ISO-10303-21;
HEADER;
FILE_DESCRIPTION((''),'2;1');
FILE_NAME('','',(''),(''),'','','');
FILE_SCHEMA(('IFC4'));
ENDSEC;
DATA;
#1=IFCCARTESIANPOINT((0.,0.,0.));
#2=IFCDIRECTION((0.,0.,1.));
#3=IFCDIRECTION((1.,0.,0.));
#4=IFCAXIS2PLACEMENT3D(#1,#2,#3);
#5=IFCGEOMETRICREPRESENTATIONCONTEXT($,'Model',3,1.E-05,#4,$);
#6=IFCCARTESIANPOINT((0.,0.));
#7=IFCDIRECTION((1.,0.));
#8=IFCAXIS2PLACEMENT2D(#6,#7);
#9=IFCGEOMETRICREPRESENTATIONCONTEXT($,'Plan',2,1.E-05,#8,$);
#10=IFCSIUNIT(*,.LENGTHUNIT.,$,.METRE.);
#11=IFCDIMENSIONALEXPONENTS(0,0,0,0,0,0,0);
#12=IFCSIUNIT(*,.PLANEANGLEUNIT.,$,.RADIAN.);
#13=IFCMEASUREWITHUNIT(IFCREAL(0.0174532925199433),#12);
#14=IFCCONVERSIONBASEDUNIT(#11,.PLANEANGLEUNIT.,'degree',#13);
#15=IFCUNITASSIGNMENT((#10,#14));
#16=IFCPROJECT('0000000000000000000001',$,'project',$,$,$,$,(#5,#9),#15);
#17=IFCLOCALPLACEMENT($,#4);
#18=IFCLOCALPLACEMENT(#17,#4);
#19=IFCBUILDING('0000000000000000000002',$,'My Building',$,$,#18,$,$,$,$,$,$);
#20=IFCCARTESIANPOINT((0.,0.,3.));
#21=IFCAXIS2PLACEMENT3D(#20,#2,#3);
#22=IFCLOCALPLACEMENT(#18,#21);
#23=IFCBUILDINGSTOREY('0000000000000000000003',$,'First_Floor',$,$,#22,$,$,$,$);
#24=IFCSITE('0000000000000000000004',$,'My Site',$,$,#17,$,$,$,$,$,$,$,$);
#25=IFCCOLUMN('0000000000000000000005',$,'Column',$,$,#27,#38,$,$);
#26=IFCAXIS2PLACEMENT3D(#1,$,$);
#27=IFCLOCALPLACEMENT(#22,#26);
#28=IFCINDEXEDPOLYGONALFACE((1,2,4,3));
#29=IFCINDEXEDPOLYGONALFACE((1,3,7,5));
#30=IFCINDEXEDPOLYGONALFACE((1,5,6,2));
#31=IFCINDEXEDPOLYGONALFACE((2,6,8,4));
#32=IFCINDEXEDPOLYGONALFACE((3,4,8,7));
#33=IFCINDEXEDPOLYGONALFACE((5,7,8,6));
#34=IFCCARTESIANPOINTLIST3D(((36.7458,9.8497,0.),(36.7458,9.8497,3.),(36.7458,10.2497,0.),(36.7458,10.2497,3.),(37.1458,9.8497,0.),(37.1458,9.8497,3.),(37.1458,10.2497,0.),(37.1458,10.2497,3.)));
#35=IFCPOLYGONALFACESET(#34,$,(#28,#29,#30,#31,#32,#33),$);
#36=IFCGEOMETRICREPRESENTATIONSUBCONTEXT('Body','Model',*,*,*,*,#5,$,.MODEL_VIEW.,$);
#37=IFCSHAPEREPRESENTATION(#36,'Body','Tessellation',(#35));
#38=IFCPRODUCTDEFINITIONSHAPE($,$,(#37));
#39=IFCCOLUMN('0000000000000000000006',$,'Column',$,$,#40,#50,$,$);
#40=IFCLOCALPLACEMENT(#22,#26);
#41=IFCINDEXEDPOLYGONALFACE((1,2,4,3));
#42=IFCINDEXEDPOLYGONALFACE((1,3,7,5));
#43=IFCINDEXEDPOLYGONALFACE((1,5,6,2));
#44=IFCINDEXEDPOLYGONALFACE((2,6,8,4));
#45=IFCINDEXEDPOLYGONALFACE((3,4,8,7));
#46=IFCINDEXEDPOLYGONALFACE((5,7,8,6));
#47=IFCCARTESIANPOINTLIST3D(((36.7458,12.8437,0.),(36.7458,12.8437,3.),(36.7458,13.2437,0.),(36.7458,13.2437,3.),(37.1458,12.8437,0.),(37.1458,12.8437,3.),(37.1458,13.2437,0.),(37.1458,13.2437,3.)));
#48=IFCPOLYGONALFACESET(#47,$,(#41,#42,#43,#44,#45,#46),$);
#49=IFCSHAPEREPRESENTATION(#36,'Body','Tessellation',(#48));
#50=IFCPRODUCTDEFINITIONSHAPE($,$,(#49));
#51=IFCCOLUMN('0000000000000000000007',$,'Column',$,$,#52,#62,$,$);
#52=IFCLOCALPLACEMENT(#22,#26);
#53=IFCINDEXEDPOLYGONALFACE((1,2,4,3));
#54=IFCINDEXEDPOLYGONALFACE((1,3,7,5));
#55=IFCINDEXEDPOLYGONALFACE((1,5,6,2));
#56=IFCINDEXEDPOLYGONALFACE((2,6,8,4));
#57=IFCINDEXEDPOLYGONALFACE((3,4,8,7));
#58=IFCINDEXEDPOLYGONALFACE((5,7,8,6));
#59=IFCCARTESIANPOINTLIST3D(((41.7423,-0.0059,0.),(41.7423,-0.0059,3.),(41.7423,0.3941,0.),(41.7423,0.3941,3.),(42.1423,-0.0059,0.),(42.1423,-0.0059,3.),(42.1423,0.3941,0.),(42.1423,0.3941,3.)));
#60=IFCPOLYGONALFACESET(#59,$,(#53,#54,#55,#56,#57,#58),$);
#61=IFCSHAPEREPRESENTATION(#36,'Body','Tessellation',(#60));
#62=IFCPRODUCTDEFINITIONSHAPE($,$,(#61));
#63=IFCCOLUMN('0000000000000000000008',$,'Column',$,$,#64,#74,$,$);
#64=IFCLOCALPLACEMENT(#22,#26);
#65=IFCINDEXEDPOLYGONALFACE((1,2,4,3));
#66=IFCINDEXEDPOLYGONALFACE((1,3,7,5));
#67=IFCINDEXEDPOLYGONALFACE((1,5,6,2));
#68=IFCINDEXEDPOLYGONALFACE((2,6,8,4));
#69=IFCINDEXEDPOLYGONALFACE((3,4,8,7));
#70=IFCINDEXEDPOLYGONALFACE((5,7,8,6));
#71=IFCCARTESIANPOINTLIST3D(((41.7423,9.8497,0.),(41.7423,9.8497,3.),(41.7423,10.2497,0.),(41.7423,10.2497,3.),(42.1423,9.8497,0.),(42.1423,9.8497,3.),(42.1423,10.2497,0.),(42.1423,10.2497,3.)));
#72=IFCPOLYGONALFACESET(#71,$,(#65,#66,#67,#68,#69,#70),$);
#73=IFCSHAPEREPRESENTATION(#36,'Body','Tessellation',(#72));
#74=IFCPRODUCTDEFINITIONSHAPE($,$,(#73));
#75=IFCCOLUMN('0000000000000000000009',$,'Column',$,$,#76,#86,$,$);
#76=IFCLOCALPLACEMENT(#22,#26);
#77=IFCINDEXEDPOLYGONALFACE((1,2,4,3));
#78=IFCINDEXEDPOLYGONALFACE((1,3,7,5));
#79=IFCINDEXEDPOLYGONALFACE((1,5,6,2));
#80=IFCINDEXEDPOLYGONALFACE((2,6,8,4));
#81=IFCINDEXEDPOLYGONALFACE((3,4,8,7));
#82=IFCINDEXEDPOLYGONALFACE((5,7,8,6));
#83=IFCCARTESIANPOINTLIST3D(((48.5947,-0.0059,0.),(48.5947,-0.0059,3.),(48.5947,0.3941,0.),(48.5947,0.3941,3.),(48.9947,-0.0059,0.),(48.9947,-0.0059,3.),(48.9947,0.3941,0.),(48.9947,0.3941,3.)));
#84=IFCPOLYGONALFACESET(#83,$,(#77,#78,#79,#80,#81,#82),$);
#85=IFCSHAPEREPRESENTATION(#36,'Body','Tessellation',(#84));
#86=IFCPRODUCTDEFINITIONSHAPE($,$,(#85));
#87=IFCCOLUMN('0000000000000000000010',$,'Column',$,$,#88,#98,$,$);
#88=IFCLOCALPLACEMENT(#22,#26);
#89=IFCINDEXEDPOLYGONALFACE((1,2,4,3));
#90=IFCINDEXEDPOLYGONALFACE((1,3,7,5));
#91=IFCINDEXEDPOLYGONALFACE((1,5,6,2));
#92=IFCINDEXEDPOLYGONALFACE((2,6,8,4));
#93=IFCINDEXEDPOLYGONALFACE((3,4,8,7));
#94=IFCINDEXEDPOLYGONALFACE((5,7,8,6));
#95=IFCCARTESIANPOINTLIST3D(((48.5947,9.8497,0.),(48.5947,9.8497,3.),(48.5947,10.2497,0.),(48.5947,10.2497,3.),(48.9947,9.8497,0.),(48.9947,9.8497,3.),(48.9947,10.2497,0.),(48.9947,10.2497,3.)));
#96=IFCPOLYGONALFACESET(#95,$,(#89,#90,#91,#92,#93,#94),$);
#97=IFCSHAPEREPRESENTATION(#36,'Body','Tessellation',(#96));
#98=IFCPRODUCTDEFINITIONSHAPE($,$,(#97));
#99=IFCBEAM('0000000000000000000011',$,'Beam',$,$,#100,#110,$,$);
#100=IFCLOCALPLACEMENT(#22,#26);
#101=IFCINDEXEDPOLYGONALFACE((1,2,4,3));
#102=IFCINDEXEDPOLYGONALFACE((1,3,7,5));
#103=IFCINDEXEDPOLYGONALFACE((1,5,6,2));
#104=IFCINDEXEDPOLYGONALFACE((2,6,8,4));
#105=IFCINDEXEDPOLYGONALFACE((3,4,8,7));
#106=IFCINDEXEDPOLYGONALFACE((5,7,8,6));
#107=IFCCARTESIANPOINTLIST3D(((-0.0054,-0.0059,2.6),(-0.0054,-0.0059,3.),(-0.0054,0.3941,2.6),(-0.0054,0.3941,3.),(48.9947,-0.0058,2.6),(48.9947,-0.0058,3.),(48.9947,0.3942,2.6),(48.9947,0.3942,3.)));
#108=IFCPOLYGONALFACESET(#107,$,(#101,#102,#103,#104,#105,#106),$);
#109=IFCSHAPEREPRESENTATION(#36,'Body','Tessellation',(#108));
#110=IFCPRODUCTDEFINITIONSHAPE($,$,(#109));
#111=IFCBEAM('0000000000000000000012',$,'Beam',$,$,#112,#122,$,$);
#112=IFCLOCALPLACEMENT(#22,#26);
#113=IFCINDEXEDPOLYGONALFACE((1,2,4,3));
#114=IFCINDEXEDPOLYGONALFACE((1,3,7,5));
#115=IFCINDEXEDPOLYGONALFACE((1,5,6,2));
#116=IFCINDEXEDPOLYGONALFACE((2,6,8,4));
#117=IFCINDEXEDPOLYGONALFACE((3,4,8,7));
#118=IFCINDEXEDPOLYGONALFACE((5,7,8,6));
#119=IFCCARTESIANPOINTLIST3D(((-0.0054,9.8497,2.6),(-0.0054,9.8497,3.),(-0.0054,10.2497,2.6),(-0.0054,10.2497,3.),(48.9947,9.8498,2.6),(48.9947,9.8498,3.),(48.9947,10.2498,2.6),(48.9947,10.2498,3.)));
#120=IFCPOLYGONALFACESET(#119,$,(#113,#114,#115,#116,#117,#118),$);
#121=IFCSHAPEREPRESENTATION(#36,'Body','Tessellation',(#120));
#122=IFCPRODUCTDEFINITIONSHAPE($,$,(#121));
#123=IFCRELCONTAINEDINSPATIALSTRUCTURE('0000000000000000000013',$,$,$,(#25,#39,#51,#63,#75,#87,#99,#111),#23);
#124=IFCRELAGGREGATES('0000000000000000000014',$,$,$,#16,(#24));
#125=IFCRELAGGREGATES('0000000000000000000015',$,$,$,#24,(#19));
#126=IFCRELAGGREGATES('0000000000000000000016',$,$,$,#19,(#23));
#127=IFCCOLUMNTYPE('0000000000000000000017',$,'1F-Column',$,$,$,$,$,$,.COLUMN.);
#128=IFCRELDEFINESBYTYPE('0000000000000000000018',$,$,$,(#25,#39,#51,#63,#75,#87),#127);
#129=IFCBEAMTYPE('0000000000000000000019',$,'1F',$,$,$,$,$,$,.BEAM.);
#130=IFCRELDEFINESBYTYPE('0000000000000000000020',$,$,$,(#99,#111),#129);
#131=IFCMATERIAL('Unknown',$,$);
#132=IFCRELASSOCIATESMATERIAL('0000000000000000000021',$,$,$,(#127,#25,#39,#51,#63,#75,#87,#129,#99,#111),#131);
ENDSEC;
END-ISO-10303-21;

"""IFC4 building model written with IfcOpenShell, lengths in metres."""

from ifc_helpers import new_model, entity, si_unit, converted_unit, frame, origin_with_axes, origin_2d_with_axis, place, context, subcontext, project, spatial, rectangle, extrude, material, material_profile, profile_set, profile_usage, type_object, element, save


model = new_model("IFC4")

# Units and contexts
model_context = context("Model", 3, precision=1e-05, world=origin_with_axes())
plan_context = context("Plan", 2, precision=1e-05, world=origin_2d_with_axis())
body_context_1 = subcontext(model_context, "Body", "Model", "MODEL_VIEW")
ifc_project = project(units=[si_unit("LENGTHUNIT", "METRE"), converted_unit("PLANEANGLEUNIT", "degree", entity("IfcReal", 0.0174532925199433), si_unit("PLANEANGLEUNIT", "RADIAN"), dimensions=[0, 0, 0, 0, 0, 0, 0])], contexts=[model_context, plan_context])

# Site, building, storey
site_placement = place(None, origin_with_axes())
site = spatial("IfcSite", under=ifc_project, at=site_placement, Name="My Site")
building_placement = place(site_placement, origin_with_axes())
building = spatial("IfcBuilding", under=site, at=building_placement, Name="My Building")
storey_placement = place(building_placement, frame((0.0, 0.0, 3.0), z_axis=(0.0, 0.0, 1.0), x_axis=(1.0, 0.0, 0.0)))
storey = spatial("IfcBuildingStorey", under=building, at=storey_placement, Name="First_Floor")

# Columns
ifc_material = material(Name="Unknown")
ifc_material_profile_1 = material_profile(ifc_material, rectangle(XDim=0.4, YDim=0.4))
ifc_profile_set_1 = profile_set([ifc_material_profile_1])
ifc_profile_usage_1 = profile_usage(ifc_profile_set_1, cardinal=5)
column_type = type_object("IfcColumnType", Name="1F-Column", PredefinedType="COLUMN", material=ifc_profile_set_1)
column_1_placement = place(storey_placement, frame((36.9458, 10.0497, 0.0), z_axis=(0.0, 0.0, 1.0), x_axis=(1.0, 0.0, 0.0)))
element("IfcColumn", 1, at=column_1_placement, inside=storey, type_object=column_type, material=ifc_profile_usage_1, Name="Column", context=body_context_1, shape_type="SweptSolid", body=[
    extrude(rectangle(XDim=0.4, YDim=0.4), origin_with_axes(), (0.0, 0.0, 1.0), 3.0),
])
ifc_profile_usage_2 = profile_usage(ifc_profile_set_1, cardinal=5)
column_2_placement = place(storey_placement, frame((36.9458, 13.0437, 0.0), z_axis=(0.0, 0.0, 1.0), x_axis=(1.0, 0.0, 0.0)))
element("IfcColumn", 2, at=column_2_placement, inside=storey, type_object=column_type, material=ifc_profile_usage_2, Name="Column", context=body_context_1, shape_type="SweptSolid", body=[
    extrude(rectangle(XDim=0.4, YDim=0.4), origin_with_axes(), (0.0, 0.0, 1.0), 3.0),
])
ifc_profile_usage_3 = profile_usage(ifc_profile_set_1, cardinal=5)
column_3_placement = place(storey_placement, frame((41.9423, 0.1941, 0.0), z_axis=(0.0, 0.0, 1.0), x_axis=(1.0, 0.0, 0.0)))
element("IfcColumn", 3, at=column_3_placement, inside=storey, type_object=column_type, material=ifc_profile_usage_3, Name="Column", context=body_context_1, shape_type="SweptSolid", body=[
    extrude(rectangle(XDim=0.4, YDim=0.4), origin_with_axes(), (0.0, 0.0, 1.0), 3.0),
])
ifc_profile_usage_4 = profile_usage(ifc_profile_set_1, cardinal=5)
column_4_placement = place(storey_placement, frame((41.9423, 10.0497, 0.0), z_axis=(0.0, 0.0, 1.0), x_axis=(1.0, 0.0, 0.0)))
element("IfcColumn", 4, at=column_4_placement, inside=storey, type_object=column_type, material=ifc_profile_usage_4, Name="Column", context=body_context_1, shape_type="SweptSolid", body=[
    extrude(rectangle(XDim=0.4, YDim=0.4), origin_with_axes(), (0.0, 0.0, 1.0), 3.0),
])
ifc_profile_usage_5 = profile_usage(ifc_profile_set_1, cardinal=5)
column_5_placement = place(storey_placement, frame((48.7947, 0.1941, 0.0), z_axis=(0.0, 0.0, 1.0), x_axis=(1.0, 0.0, 0.0)))
element("IfcColumn", 5, at=column_5_placement, inside=storey, type_object=column_type, material=ifc_profile_usage_5, Name="Column", context=body_context_1, shape_type="SweptSolid", body=[
    extrude(rectangle(XDim=0.4, YDim=0.4), origin_with_axes(), (0.0, 0.0, 1.0), 3.0),
])
ifc_profile_usage_6 = profile_usage(ifc_profile_set_1, cardinal=5)
column_6_placement = place(storey_placement, frame((48.7947, 10.0497, 0.0), z_axis=(0.0, 0.0, 1.0), x_axis=(1.0, 0.0, 0.0)))
element("IfcColumn", 6, at=column_6_placement, inside=storey, type_object=column_type, material=ifc_profile_usage_6, Name="Column", context=body_context_1, shape_type="SweptSolid", body=[
    extrude(rectangle(XDim=0.4, YDim=0.4), origin_with_axes(), (0.0, 0.0, 1.0), 3.0),
])

# Beams
ifc_material_profile_2 = material_profile(ifc_material, rectangle(XDim=0.4, YDim=0.4))
ifc_profile_set_2 = profile_set([ifc_material_profile_2])
ifc_profile_usage_7 = profile_usage(ifc_profile_set_2, cardinal=8)
beam_type = type_object("IfcBeamType", Name="1F", PredefinedType="BEAM", material=ifc_profile_set_2)
beam_1_placement = place(storey_placement, frame((48.9947, 0.1942, 3.0), z_axis=(-1.0, 0.0, 0.0), x_axis=(0.0, -1.0, 0.0)))
element("IfcBeam", 7, at=beam_1_placement, inside=storey, type_object=beam_type, material=ifc_profile_usage_7, Name="Beam", context=body_context_1, shape_type="SweptSolid", body=[
    extrude(rectangle(XDim=0.4, YDim=0.4), frame((0.0, -0.2, 0.0), z_axis=(0.0, 0.0, 1.0), x_axis=(1.0, 0.0, 0.0)), (0.0, 0.0, 1.0), 49.0001),
])
ifc_profile_usage_8 = profile_usage(ifc_profile_set_2, cardinal=8)
beam_2_placement = place(storey_placement, frame((48.9947, 10.0498, 3.0), z_axis=(-1.0, 0.0, 0.0), x_axis=(0.0, -1.0, 0.0)))
element("IfcBeam", 8, at=beam_2_placement, inside=storey, type_object=beam_type, material=ifc_profile_usage_8, Name="Beam", context=body_context_1, shape_type="SweptSolid", body=[
    extrude(rectangle(XDim=0.4, YDim=0.4), frame((0.0, -0.2, 0.0), z_axis=(0.0, 0.0, 1.0), x_axis=(1.0, 0.0, 0.0)), (0.0, 0.0, 1.0), 49.0001),
])

save(model, "model.ifc")
